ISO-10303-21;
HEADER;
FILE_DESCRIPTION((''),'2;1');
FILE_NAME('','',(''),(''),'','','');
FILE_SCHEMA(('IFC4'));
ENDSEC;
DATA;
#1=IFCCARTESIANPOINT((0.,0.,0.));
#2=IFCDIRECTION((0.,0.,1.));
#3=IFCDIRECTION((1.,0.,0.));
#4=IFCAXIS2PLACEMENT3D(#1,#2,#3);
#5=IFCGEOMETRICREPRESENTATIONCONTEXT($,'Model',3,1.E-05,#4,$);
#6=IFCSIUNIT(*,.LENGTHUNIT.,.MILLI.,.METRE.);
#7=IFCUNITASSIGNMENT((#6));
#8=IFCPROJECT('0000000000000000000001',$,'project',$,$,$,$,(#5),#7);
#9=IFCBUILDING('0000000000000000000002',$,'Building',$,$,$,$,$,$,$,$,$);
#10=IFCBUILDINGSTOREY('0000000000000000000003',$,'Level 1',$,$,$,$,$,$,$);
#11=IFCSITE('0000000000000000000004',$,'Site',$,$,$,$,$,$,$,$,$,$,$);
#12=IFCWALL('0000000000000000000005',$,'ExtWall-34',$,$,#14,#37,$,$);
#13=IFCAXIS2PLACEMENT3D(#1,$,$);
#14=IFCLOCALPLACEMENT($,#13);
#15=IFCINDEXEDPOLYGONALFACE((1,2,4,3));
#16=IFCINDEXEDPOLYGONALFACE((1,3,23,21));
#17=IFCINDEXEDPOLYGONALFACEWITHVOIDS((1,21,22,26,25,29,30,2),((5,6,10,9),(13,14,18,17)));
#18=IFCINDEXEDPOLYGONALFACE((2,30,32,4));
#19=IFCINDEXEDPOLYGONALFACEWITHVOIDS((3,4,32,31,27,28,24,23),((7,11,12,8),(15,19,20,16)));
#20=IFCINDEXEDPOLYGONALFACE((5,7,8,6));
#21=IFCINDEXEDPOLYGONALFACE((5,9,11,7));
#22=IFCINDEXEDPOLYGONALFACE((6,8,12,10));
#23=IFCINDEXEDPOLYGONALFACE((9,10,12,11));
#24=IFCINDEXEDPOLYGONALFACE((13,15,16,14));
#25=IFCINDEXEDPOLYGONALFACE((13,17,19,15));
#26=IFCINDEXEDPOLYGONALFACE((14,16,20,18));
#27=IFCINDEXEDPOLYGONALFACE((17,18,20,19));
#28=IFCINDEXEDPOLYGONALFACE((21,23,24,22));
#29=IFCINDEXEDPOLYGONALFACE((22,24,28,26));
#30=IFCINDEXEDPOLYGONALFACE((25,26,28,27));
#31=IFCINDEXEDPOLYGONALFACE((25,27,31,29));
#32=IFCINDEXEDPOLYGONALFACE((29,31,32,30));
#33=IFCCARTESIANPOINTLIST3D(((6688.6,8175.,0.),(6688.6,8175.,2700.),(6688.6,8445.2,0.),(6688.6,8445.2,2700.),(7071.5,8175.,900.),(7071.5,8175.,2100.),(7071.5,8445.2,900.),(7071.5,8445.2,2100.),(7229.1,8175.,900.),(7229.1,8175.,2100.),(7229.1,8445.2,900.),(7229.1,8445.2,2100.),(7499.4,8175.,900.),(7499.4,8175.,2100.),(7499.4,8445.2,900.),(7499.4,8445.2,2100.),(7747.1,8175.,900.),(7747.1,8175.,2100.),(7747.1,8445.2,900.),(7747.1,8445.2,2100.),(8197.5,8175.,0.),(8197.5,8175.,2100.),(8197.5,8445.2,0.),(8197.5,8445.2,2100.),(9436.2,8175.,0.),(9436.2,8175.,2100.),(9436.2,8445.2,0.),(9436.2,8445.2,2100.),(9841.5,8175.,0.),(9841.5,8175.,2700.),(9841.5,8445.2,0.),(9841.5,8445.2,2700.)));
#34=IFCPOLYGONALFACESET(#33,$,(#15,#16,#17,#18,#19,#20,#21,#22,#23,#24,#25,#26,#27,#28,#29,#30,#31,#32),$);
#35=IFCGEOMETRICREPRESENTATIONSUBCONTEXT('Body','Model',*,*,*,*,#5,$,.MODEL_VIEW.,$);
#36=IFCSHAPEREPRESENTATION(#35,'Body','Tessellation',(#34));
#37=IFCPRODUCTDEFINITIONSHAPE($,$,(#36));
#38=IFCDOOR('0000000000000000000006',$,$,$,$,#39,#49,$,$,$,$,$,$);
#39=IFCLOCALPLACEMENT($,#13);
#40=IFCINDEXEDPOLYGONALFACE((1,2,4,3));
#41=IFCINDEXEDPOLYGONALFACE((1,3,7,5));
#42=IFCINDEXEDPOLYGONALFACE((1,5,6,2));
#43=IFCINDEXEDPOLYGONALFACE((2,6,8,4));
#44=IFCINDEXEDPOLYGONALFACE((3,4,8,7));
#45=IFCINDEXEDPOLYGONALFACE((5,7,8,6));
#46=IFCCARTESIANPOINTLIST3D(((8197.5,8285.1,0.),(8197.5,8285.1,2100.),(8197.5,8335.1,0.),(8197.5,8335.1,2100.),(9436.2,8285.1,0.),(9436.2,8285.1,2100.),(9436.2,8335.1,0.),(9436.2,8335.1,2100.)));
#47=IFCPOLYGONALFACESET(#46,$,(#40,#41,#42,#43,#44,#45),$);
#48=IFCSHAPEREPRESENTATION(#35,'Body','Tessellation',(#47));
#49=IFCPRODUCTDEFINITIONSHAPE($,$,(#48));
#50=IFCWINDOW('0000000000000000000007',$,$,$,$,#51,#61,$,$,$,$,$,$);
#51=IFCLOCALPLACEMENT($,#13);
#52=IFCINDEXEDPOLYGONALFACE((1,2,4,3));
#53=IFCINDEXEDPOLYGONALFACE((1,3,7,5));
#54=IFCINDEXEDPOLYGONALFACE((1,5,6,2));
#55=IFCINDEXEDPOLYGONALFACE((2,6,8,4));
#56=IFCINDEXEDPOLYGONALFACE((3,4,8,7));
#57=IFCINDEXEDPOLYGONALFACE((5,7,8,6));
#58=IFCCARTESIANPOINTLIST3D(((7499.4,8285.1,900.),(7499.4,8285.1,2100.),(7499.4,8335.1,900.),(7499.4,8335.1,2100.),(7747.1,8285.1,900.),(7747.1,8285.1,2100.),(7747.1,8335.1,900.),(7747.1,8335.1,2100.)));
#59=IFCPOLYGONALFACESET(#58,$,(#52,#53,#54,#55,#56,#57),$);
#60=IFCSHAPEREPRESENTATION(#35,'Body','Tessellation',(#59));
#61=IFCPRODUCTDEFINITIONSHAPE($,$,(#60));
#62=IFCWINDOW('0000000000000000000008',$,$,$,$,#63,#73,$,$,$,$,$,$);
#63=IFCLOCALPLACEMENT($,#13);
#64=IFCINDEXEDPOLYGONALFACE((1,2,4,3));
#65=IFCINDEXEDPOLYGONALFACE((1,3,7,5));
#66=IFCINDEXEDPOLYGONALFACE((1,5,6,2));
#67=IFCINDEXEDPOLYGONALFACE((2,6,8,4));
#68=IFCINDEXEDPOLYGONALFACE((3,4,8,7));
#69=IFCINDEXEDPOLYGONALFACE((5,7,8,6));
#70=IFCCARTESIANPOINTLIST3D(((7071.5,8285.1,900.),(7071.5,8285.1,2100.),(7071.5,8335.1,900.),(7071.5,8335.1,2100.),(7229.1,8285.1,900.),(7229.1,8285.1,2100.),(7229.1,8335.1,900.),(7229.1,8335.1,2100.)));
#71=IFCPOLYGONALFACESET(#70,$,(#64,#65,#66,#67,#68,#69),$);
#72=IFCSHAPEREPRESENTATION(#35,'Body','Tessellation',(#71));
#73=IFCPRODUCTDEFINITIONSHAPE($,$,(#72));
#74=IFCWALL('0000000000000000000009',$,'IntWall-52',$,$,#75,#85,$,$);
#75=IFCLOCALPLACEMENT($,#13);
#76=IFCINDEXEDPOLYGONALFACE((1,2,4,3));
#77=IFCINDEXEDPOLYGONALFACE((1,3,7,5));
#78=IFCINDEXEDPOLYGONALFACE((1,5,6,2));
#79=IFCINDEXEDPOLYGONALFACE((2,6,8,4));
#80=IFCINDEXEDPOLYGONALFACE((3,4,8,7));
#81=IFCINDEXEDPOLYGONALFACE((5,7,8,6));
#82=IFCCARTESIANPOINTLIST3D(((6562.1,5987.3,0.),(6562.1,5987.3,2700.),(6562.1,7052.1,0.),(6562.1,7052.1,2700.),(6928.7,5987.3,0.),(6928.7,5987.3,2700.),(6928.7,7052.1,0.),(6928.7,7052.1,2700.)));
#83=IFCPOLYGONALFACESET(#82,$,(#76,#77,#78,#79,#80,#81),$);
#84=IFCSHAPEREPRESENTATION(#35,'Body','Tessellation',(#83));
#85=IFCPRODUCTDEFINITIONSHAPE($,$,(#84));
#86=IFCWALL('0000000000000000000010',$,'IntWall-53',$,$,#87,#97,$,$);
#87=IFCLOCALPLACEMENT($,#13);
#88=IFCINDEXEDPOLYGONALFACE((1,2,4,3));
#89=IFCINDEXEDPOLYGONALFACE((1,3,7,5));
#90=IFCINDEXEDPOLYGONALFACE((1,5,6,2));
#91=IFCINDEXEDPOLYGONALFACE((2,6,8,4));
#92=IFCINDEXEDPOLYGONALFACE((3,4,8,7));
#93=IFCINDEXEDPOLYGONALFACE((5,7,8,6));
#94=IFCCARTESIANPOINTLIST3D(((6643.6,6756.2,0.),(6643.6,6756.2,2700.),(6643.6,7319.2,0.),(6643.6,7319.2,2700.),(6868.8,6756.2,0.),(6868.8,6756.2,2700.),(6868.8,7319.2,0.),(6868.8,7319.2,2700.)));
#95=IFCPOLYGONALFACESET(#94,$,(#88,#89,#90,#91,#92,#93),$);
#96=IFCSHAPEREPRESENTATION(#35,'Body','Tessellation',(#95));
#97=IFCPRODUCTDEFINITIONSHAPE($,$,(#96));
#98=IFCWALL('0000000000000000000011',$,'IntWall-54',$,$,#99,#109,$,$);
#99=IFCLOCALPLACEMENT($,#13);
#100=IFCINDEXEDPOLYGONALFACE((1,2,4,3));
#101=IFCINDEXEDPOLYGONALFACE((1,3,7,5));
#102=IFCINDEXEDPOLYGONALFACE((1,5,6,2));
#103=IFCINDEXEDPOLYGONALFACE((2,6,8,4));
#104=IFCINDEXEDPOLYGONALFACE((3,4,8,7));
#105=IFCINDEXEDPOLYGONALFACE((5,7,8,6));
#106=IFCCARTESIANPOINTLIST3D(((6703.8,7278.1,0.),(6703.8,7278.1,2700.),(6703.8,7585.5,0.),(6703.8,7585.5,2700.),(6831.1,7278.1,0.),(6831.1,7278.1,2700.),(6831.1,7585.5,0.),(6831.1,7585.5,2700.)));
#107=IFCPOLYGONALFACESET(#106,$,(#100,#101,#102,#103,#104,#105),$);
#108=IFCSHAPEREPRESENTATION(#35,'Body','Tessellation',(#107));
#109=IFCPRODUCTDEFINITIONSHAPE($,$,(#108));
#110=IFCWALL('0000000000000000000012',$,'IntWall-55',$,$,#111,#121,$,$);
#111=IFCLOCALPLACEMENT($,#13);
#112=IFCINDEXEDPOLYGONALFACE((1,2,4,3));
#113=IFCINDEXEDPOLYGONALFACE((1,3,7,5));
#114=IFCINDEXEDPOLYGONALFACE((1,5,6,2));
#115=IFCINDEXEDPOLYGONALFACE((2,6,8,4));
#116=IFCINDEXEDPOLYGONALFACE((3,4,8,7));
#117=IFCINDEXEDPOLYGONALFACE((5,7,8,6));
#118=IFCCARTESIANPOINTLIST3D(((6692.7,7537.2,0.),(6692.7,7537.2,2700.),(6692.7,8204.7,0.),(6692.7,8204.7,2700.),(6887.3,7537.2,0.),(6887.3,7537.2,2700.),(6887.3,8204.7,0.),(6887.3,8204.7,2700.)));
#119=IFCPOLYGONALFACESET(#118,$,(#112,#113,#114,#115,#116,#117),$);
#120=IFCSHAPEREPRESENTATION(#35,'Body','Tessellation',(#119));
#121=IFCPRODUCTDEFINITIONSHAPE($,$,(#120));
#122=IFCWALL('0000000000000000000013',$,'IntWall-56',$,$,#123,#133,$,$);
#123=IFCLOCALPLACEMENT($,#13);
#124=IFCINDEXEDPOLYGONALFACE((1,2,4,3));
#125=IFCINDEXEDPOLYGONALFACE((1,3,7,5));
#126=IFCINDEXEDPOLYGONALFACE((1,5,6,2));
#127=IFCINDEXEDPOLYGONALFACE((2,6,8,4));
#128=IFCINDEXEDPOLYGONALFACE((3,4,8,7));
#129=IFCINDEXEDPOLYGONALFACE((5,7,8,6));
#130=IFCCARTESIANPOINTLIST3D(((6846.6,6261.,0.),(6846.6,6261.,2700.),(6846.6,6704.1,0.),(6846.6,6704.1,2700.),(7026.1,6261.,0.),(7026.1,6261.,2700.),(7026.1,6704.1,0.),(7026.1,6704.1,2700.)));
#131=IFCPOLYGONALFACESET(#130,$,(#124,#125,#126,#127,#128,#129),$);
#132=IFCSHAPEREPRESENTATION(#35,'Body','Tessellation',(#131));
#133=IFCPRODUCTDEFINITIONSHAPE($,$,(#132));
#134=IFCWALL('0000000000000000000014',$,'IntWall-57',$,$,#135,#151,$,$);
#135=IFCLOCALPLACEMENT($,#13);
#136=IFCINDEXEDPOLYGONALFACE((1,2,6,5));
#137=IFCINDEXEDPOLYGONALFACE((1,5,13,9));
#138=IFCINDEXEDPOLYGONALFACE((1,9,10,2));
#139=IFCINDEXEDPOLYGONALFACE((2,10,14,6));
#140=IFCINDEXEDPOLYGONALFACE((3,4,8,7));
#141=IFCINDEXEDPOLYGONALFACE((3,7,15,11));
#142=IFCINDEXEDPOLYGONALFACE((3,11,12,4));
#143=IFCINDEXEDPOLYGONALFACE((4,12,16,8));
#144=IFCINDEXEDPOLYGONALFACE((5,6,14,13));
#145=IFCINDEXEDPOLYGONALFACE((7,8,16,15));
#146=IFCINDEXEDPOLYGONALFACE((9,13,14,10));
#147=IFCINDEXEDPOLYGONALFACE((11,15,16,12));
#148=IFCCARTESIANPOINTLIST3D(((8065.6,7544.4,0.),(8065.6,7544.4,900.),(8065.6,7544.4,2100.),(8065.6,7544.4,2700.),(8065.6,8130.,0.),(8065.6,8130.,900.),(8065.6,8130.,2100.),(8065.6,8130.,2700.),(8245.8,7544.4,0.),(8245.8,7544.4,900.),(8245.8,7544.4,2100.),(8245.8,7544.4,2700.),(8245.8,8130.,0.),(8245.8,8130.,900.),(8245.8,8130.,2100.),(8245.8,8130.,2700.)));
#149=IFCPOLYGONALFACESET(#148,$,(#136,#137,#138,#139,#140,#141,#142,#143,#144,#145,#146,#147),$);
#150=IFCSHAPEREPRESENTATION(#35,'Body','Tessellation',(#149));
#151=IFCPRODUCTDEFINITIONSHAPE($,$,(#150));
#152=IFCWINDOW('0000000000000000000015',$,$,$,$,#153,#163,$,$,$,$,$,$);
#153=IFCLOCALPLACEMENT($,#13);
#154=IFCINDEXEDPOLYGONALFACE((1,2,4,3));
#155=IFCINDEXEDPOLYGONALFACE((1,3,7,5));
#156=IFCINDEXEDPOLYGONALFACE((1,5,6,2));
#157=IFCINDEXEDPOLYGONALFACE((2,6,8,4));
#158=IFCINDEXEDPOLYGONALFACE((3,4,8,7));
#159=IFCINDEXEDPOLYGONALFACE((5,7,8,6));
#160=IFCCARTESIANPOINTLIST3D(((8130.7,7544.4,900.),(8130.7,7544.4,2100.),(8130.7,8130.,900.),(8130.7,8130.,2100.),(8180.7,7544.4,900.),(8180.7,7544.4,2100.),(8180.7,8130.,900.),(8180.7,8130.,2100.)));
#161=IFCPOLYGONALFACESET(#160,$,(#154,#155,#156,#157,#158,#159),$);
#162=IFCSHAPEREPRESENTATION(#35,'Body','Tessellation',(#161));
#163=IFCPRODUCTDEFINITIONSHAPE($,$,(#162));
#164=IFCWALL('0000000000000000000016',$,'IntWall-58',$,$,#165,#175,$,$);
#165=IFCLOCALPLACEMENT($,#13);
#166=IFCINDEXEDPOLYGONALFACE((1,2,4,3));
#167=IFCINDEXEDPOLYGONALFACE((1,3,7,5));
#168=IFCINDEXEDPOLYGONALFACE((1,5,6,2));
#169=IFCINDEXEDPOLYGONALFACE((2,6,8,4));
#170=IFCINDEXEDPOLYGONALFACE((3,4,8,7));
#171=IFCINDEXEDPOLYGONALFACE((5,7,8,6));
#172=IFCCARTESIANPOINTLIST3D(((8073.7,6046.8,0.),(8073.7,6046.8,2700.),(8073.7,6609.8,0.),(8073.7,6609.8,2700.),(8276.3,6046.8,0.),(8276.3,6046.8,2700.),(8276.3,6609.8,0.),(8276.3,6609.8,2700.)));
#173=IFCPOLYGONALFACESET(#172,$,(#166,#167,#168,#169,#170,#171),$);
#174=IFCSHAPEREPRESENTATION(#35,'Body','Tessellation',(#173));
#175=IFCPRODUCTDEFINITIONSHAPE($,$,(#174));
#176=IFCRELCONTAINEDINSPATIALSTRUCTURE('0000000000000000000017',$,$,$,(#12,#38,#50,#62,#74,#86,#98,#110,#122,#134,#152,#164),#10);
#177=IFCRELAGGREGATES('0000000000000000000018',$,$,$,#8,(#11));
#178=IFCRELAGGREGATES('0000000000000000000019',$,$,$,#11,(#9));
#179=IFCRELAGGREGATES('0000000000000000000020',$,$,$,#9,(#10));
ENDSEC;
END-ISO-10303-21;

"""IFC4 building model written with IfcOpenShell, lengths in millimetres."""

from ifc_helpers import new_model, si_unit, frame, origin_with_axes, place, context, subcontext, project, spatial, indexed_curve, outline, extrude, element, fill, save


model = new_model("IFC4")

# Units and contexts
model_context = context("Model", 3, precision=1e-05, world=origin_with_axes())
body_context = subcontext(model_context, "Body", "Model", "MODEL_VIEW")
ifc_project = project(units=[si_unit("LENGTHUNIT", "METRE", prefix="MILLI")], contexts=[model_context])

# Site, building, storey
site = spatial("IfcSite", under=ifc_project, Name="Site")
building = spatial("IfcBuilding", under=site, Name="Building")
storey = spatial("IfcBuildingStorey", under=building, Name="Level 1")

# Wall, openings, door, windows
wall_1_placement = place(None, frame((6688.6, 8310.1, 0.0), z_axis=(0.0, 0.0, 1.0), x_axis=(1.0, 0.0, 0.0)))
wall_1 = element("IfcWall", 1, at=wall_1_placement, inside=storey, Name="ExtWall-34", context=body_context, shape_type="SweptSolid", body=[
    extrude(outline(indexed_curve([(0.0, 0.0), (0.0, 270.2), (3152.9, 270.2), (3152.9, 0.0), (0.0, 0.0)], self_intersect=False)), frame((0.0, -135.1, 0.0), z_axis=(0.0, 0.0, 1.0), x_axis=(1.0, 0.0, 0.0)), (0.0, 0.0, 1.0), 2700.0),
])
opening_1_placement = place(wall_1_placement, frame((1508.9, 0.0, 0.0), z_axis=(0.0, 0.0, 1.0), x_axis=(1.0, 0.0, 0.0)))
opening_1 = element("IfcOpeningElement", 2, at=opening_1_placement, cuts=wall_1, context=body_context, shape_type="SweptSolid", body=[
    extrude(outline(indexed_curve([(0.0, 0.0), (0.0, 370.2), (1238.6, 370.2), (1238.6, 0.0), (0.0, 0.0)], self_intersect=False)), frame((0.0, -185.1, 0.0), z_axis=(0.0, 0.0, 1.0), x_axis=(1.0, 0.0, 0.0)), (0.0, 0.0, 1.0), 2100.0),
])
opening_2_placement = place(wall_1_placement, frame((810.7, 0.0, 900.0), z_axis=(0.0, 0.0, 1.0), x_axis=(1.0, 0.0, 0.0)))
opening_2 = element("IfcOpeningElement", 3, at=opening_2_placement, cuts=wall_1, context=body_context, shape_type="SweptSolid", body=[
    extrude(outline(indexed_curve([(0.0, 0.0), (0.0, 370.2), (247.7, 370.2), (247.7, 0.0), (0.0, 0.0)], self_intersect=False)), frame((0.0, -185.1, 0.0), z_axis=(0.0, 0.0, 1.0), x_axis=(1.0, 0.0, 0.0)), (0.0, 0.0, 1.0), 1200.0),
])
opening_3_placement = place(wall_1_placement, frame((382.9, 0.0, 900.0), z_axis=(0.0, 0.0, 1.0), x_axis=(1.0, 0.0, 0.0)))
opening_3 = element("IfcOpeningElement", 4, at=opening_3_placement, cuts=wall_1, context=body_context, shape_type="SweptSolid", body=[
    extrude(outline(indexed_curve([(0.0, 0.0), (0.0, 370.2), (157.6, 370.2), (157.6, 0.0), (0.0, 0.0)], self_intersect=False)), frame((0.0, -185.1, 0.0), z_axis=(0.0, 0.0, 1.0), x_axis=(1.0, 0.0, 0.0)), (0.0, 0.0, 1.0), 1200.0),
])
door_1_placement = place(opening_1_placement, origin_with_axes())
door_1 = element("IfcDoor", 5, at=door_1_placement, inside=storey, context=body_context, shape_type="SweptSolid", body=[
    extrude(outline(indexed_curve([(0.0, 0.0), (0.0, 50.0), (1238.6, 50.0), (1238.6, 0.0), (0.0, 0.0)], self_intersect=False)), frame((0.0, -25.0, 0.0), z_axis=(0.0, 0.0, 1.0), x_axis=(1.0, 0.0, 0.0)), (0.0, 0.0, 1.0), 2100.0),
])
fill(opening_1, door_1)
window_1_placement = place(opening_2_placement, origin_with_axes())
window_1 = element("IfcWindow", 6, at=window_1_placement, inside=storey, context=body_context, shape_type="SweptSolid", body=[
    extrude(outline(indexed_curve([(0.0, 0.0), (0.0, 50.0), (247.7, 50.0), (247.7, 0.0), (0.0, 0.0)], self_intersect=False)), frame((0.0, -25.0, 0.0), z_axis=(0.0, 0.0, 1.0), x_axis=(1.0, 0.0, 0.0)), (0.0, 0.0, 1.0), 1200.0),
])
fill(opening_2, window_1)
window_2_placement = place(opening_3_placement, origin_with_axes())
window_2 = element("IfcWindow", 7, at=window_2_placement, inside=storey, context=body_context, shape_type="SweptSolid", body=[
    extrude(outline(indexed_curve([(0.0, 0.0), (0.0, 50.0), (157.6, 50.0), (157.6, 0.0), (0.0, 0.0)], self_intersect=False)), frame((0.0, -25.0, 0.0), z_axis=(0.0, 0.0, 1.0), x_axis=(1.0, 0.0, 0.0)), (0.0, 0.0, 1.0), 1200.0),
])
fill(opening_3, window_2)

# Walls
wall_2_placement = place(None, frame((6745.4, 5987.3, 0.0), z_axis=(0.0, 0.0, 1.0), x_axis=(0.0, 1.0, 0.0)))
element("IfcWall", 8, at=wall_2_placement, inside=storey, Name="IntWall-52", context=body_context, shape_type="SweptSolid", body=[
    extrude(outline(indexed_curve([(0.0, 0.0), (0.0, 366.6), (1064.8, 366.6), (1064.8, 0.0), (0.0, 0.0)], self_intersect=False)), frame((0.0, -183.3, 0.0), z_axis=(0.0, 0.0, 1.0), x_axis=(1.0, 0.0, 0.0)), (0.0, 0.0, 1.0), 2700.0),
])
wall_3_placement = place(None, frame((6756.2, 6756.2, 0.0), z_axis=(0.0, 0.0, 1.0), x_axis=(0.0, 1.0, 0.0)))
element("IfcWall", 9, at=wall_3_placement, inside=storey, Name="IntWall-53", context=body_context, shape_type="SweptSolid", body=[
    extrude(outline(indexed_curve([(0.0, 0.0), (0.0, 225.2), (563.0, 225.2), (563.0, 0.0), (0.0, 0.0)], self_intersect=False)), frame((0.0, -112.6, 0.0), z_axis=(0.0, 0.0, 1.0), x_axis=(1.0, 0.0, 0.0)), (0.0, 0.0, 1.0), 2700.0),
])
wall_4_placement = place(None, frame((6767.5, 7278.1, 0.0), z_axis=(0.0, 0.0, 1.0), x_axis=(0.0, 1.0, 0.0)))
element("IfcWall", 10, at=wall_4_placement, inside=storey, Name="IntWall-54", context=body_context, shape_type="SweptSolid", body=[
    extrude(outline(indexed_curve([(0.0, 0.0), (0.0, 127.2), (307.4, 127.2), (307.4, 0.0), (0.0, 0.0)], self_intersect=False)), frame((0.0, -63.6, 0.0), z_axis=(0.0, 0.0, 1.0), x_axis=(1.0, 0.0, 0.0)), (0.0, 0.0, 1.0), 2700.0),
])
wall_5_placement = place(None, frame((6790.0, 7537.2, 0.0), z_axis=(0.0, 0.0, 1.0), x_axis=(0.0, 1.0, 0.0)))
element("IfcWall", 11, at=wall_5_placement, inside=storey, Name="IntWall-55", context=body_context, shape_type="SweptSolid", body=[
    extrude(outline(indexed_curve([(0.0, 0.0), (0.0, 194.6), (667.5, 194.6), (667.5, 0.0), (0.0, 0.0)], self_intersect=False)), frame((0.0, -97.3, 0.0), z_axis=(0.0, 0.0, 1.0), x_axis=(1.0, 0.0, 0.0)), (0.0, 0.0, 1.0), 2700.0),
])
wall_6_placement = place(None, frame((6936.4, 6261.0, 0.0), z_axis=(0.0, 0.0, 1.0), x_axis=(0.0, 1.0, 0.0)))
element("IfcWall", 12, at=wall_6_placement, inside=storey, Name="IntWall-56", context=body_context, shape_type="SweptSolid", body=[
    extrude(outline(indexed_curve([(0.0, 0.0), (0.0, 179.6), (443.0, 179.6), (443.0, 0.0), (0.0, 0.0)], self_intersect=False)), frame((0.0, -89.8, 0.0), z_axis=(0.0, 0.0, 1.0), x_axis=(1.0, 0.0, 0.0)), (0.0, 0.0, 1.0), 2700.0),
])

# Wall, opening, window
wall_7_placement = place(None, frame((8155.7, 7544.4, 0.0), z_axis=(0.0, 0.0, 1.0), x_axis=(0.0, 1.0, 0.0)))
wall_7 = element("IfcWall", 13, at=wall_7_placement, inside=storey, Name="IntWall-57", context=body_context, shape_type="SweptSolid", body=[
    extrude(outline(indexed_curve([(0.0, 0.0), (0.0, 180.2), (585.5, 180.2), (585.5, 0.0), (0.0, 0.0)], self_intersect=False)), frame((0.0, -90.1, 0.0), z_axis=(0.0, 0.0, 1.0), x_axis=(1.0, 0.0, 0.0)), (0.0, 0.0, 1.0), 2700.0),
])
opening_4_placement = place(wall_7_placement, frame((0.0, 0.0, 900.0), z_axis=(0.0, 0.0, 1.0), x_axis=(1.0, 0.0, 0.0)))
opening_4 = element("IfcOpeningElement", 14, at=opening_4_placement, cuts=wall_7, context=body_context, shape_type="SweptSolid", body=[
    extrude(outline(indexed_curve([(0.0, 0.0), (0.0, 280.2), (585.5, 280.2), (585.5, 0.0), (0.0, 0.0)], self_intersect=False)), frame((0.0, -140.1, 0.0), z_axis=(0.0, 0.0, 1.0), x_axis=(1.0, 0.0, 0.0)), (0.0, 0.0, 1.0), 1200.0),
])
window_3_placement = place(opening_4_placement, origin_with_axes())
window_3 = element("IfcWindow", 15, at=window_3_placement, inside=storey, context=body_context, shape_type="SweptSolid", body=[
    extrude(outline(indexed_curve([(0.0, 0.0), (0.0, 50.0), (585.5, 50.0), (585.5, 0.0), (0.0, 0.0)], self_intersect=False)), frame((0.0, -25.0, 0.0), z_axis=(0.0, 0.0, 1.0), x_axis=(1.0, 0.0, 0.0)), (0.0, 0.0, 1.0), 1200.0),
])
fill(opening_4, window_3)

# Wall
wall_8_placement = place(None, frame((8175.0, 6046.8, 0.0), z_axis=(0.0, 0.0, 1.0), x_axis=(0.0, 1.0, 0.0)))
element("IfcWall", 16, at=wall_8_placement, inside=storey, Name="IntWall-58", context=body_context, shape_type="SweptSolid", body=[
    extrude(outline(indexed_curve([(0.0, 0.0), (0.0, 202.7), (563.0, 202.7), (563.0, 0.0), (0.0, 0.0)], self_intersect=False)), frame((0.0, -101.3, 0.0), z_axis=(0.0, 0.0, 1.0), x_axis=(1.0, 0.0, 0.0)), (0.0, 0.0, 1.0), 2700.0),
])

save(model, "model.ifc")
